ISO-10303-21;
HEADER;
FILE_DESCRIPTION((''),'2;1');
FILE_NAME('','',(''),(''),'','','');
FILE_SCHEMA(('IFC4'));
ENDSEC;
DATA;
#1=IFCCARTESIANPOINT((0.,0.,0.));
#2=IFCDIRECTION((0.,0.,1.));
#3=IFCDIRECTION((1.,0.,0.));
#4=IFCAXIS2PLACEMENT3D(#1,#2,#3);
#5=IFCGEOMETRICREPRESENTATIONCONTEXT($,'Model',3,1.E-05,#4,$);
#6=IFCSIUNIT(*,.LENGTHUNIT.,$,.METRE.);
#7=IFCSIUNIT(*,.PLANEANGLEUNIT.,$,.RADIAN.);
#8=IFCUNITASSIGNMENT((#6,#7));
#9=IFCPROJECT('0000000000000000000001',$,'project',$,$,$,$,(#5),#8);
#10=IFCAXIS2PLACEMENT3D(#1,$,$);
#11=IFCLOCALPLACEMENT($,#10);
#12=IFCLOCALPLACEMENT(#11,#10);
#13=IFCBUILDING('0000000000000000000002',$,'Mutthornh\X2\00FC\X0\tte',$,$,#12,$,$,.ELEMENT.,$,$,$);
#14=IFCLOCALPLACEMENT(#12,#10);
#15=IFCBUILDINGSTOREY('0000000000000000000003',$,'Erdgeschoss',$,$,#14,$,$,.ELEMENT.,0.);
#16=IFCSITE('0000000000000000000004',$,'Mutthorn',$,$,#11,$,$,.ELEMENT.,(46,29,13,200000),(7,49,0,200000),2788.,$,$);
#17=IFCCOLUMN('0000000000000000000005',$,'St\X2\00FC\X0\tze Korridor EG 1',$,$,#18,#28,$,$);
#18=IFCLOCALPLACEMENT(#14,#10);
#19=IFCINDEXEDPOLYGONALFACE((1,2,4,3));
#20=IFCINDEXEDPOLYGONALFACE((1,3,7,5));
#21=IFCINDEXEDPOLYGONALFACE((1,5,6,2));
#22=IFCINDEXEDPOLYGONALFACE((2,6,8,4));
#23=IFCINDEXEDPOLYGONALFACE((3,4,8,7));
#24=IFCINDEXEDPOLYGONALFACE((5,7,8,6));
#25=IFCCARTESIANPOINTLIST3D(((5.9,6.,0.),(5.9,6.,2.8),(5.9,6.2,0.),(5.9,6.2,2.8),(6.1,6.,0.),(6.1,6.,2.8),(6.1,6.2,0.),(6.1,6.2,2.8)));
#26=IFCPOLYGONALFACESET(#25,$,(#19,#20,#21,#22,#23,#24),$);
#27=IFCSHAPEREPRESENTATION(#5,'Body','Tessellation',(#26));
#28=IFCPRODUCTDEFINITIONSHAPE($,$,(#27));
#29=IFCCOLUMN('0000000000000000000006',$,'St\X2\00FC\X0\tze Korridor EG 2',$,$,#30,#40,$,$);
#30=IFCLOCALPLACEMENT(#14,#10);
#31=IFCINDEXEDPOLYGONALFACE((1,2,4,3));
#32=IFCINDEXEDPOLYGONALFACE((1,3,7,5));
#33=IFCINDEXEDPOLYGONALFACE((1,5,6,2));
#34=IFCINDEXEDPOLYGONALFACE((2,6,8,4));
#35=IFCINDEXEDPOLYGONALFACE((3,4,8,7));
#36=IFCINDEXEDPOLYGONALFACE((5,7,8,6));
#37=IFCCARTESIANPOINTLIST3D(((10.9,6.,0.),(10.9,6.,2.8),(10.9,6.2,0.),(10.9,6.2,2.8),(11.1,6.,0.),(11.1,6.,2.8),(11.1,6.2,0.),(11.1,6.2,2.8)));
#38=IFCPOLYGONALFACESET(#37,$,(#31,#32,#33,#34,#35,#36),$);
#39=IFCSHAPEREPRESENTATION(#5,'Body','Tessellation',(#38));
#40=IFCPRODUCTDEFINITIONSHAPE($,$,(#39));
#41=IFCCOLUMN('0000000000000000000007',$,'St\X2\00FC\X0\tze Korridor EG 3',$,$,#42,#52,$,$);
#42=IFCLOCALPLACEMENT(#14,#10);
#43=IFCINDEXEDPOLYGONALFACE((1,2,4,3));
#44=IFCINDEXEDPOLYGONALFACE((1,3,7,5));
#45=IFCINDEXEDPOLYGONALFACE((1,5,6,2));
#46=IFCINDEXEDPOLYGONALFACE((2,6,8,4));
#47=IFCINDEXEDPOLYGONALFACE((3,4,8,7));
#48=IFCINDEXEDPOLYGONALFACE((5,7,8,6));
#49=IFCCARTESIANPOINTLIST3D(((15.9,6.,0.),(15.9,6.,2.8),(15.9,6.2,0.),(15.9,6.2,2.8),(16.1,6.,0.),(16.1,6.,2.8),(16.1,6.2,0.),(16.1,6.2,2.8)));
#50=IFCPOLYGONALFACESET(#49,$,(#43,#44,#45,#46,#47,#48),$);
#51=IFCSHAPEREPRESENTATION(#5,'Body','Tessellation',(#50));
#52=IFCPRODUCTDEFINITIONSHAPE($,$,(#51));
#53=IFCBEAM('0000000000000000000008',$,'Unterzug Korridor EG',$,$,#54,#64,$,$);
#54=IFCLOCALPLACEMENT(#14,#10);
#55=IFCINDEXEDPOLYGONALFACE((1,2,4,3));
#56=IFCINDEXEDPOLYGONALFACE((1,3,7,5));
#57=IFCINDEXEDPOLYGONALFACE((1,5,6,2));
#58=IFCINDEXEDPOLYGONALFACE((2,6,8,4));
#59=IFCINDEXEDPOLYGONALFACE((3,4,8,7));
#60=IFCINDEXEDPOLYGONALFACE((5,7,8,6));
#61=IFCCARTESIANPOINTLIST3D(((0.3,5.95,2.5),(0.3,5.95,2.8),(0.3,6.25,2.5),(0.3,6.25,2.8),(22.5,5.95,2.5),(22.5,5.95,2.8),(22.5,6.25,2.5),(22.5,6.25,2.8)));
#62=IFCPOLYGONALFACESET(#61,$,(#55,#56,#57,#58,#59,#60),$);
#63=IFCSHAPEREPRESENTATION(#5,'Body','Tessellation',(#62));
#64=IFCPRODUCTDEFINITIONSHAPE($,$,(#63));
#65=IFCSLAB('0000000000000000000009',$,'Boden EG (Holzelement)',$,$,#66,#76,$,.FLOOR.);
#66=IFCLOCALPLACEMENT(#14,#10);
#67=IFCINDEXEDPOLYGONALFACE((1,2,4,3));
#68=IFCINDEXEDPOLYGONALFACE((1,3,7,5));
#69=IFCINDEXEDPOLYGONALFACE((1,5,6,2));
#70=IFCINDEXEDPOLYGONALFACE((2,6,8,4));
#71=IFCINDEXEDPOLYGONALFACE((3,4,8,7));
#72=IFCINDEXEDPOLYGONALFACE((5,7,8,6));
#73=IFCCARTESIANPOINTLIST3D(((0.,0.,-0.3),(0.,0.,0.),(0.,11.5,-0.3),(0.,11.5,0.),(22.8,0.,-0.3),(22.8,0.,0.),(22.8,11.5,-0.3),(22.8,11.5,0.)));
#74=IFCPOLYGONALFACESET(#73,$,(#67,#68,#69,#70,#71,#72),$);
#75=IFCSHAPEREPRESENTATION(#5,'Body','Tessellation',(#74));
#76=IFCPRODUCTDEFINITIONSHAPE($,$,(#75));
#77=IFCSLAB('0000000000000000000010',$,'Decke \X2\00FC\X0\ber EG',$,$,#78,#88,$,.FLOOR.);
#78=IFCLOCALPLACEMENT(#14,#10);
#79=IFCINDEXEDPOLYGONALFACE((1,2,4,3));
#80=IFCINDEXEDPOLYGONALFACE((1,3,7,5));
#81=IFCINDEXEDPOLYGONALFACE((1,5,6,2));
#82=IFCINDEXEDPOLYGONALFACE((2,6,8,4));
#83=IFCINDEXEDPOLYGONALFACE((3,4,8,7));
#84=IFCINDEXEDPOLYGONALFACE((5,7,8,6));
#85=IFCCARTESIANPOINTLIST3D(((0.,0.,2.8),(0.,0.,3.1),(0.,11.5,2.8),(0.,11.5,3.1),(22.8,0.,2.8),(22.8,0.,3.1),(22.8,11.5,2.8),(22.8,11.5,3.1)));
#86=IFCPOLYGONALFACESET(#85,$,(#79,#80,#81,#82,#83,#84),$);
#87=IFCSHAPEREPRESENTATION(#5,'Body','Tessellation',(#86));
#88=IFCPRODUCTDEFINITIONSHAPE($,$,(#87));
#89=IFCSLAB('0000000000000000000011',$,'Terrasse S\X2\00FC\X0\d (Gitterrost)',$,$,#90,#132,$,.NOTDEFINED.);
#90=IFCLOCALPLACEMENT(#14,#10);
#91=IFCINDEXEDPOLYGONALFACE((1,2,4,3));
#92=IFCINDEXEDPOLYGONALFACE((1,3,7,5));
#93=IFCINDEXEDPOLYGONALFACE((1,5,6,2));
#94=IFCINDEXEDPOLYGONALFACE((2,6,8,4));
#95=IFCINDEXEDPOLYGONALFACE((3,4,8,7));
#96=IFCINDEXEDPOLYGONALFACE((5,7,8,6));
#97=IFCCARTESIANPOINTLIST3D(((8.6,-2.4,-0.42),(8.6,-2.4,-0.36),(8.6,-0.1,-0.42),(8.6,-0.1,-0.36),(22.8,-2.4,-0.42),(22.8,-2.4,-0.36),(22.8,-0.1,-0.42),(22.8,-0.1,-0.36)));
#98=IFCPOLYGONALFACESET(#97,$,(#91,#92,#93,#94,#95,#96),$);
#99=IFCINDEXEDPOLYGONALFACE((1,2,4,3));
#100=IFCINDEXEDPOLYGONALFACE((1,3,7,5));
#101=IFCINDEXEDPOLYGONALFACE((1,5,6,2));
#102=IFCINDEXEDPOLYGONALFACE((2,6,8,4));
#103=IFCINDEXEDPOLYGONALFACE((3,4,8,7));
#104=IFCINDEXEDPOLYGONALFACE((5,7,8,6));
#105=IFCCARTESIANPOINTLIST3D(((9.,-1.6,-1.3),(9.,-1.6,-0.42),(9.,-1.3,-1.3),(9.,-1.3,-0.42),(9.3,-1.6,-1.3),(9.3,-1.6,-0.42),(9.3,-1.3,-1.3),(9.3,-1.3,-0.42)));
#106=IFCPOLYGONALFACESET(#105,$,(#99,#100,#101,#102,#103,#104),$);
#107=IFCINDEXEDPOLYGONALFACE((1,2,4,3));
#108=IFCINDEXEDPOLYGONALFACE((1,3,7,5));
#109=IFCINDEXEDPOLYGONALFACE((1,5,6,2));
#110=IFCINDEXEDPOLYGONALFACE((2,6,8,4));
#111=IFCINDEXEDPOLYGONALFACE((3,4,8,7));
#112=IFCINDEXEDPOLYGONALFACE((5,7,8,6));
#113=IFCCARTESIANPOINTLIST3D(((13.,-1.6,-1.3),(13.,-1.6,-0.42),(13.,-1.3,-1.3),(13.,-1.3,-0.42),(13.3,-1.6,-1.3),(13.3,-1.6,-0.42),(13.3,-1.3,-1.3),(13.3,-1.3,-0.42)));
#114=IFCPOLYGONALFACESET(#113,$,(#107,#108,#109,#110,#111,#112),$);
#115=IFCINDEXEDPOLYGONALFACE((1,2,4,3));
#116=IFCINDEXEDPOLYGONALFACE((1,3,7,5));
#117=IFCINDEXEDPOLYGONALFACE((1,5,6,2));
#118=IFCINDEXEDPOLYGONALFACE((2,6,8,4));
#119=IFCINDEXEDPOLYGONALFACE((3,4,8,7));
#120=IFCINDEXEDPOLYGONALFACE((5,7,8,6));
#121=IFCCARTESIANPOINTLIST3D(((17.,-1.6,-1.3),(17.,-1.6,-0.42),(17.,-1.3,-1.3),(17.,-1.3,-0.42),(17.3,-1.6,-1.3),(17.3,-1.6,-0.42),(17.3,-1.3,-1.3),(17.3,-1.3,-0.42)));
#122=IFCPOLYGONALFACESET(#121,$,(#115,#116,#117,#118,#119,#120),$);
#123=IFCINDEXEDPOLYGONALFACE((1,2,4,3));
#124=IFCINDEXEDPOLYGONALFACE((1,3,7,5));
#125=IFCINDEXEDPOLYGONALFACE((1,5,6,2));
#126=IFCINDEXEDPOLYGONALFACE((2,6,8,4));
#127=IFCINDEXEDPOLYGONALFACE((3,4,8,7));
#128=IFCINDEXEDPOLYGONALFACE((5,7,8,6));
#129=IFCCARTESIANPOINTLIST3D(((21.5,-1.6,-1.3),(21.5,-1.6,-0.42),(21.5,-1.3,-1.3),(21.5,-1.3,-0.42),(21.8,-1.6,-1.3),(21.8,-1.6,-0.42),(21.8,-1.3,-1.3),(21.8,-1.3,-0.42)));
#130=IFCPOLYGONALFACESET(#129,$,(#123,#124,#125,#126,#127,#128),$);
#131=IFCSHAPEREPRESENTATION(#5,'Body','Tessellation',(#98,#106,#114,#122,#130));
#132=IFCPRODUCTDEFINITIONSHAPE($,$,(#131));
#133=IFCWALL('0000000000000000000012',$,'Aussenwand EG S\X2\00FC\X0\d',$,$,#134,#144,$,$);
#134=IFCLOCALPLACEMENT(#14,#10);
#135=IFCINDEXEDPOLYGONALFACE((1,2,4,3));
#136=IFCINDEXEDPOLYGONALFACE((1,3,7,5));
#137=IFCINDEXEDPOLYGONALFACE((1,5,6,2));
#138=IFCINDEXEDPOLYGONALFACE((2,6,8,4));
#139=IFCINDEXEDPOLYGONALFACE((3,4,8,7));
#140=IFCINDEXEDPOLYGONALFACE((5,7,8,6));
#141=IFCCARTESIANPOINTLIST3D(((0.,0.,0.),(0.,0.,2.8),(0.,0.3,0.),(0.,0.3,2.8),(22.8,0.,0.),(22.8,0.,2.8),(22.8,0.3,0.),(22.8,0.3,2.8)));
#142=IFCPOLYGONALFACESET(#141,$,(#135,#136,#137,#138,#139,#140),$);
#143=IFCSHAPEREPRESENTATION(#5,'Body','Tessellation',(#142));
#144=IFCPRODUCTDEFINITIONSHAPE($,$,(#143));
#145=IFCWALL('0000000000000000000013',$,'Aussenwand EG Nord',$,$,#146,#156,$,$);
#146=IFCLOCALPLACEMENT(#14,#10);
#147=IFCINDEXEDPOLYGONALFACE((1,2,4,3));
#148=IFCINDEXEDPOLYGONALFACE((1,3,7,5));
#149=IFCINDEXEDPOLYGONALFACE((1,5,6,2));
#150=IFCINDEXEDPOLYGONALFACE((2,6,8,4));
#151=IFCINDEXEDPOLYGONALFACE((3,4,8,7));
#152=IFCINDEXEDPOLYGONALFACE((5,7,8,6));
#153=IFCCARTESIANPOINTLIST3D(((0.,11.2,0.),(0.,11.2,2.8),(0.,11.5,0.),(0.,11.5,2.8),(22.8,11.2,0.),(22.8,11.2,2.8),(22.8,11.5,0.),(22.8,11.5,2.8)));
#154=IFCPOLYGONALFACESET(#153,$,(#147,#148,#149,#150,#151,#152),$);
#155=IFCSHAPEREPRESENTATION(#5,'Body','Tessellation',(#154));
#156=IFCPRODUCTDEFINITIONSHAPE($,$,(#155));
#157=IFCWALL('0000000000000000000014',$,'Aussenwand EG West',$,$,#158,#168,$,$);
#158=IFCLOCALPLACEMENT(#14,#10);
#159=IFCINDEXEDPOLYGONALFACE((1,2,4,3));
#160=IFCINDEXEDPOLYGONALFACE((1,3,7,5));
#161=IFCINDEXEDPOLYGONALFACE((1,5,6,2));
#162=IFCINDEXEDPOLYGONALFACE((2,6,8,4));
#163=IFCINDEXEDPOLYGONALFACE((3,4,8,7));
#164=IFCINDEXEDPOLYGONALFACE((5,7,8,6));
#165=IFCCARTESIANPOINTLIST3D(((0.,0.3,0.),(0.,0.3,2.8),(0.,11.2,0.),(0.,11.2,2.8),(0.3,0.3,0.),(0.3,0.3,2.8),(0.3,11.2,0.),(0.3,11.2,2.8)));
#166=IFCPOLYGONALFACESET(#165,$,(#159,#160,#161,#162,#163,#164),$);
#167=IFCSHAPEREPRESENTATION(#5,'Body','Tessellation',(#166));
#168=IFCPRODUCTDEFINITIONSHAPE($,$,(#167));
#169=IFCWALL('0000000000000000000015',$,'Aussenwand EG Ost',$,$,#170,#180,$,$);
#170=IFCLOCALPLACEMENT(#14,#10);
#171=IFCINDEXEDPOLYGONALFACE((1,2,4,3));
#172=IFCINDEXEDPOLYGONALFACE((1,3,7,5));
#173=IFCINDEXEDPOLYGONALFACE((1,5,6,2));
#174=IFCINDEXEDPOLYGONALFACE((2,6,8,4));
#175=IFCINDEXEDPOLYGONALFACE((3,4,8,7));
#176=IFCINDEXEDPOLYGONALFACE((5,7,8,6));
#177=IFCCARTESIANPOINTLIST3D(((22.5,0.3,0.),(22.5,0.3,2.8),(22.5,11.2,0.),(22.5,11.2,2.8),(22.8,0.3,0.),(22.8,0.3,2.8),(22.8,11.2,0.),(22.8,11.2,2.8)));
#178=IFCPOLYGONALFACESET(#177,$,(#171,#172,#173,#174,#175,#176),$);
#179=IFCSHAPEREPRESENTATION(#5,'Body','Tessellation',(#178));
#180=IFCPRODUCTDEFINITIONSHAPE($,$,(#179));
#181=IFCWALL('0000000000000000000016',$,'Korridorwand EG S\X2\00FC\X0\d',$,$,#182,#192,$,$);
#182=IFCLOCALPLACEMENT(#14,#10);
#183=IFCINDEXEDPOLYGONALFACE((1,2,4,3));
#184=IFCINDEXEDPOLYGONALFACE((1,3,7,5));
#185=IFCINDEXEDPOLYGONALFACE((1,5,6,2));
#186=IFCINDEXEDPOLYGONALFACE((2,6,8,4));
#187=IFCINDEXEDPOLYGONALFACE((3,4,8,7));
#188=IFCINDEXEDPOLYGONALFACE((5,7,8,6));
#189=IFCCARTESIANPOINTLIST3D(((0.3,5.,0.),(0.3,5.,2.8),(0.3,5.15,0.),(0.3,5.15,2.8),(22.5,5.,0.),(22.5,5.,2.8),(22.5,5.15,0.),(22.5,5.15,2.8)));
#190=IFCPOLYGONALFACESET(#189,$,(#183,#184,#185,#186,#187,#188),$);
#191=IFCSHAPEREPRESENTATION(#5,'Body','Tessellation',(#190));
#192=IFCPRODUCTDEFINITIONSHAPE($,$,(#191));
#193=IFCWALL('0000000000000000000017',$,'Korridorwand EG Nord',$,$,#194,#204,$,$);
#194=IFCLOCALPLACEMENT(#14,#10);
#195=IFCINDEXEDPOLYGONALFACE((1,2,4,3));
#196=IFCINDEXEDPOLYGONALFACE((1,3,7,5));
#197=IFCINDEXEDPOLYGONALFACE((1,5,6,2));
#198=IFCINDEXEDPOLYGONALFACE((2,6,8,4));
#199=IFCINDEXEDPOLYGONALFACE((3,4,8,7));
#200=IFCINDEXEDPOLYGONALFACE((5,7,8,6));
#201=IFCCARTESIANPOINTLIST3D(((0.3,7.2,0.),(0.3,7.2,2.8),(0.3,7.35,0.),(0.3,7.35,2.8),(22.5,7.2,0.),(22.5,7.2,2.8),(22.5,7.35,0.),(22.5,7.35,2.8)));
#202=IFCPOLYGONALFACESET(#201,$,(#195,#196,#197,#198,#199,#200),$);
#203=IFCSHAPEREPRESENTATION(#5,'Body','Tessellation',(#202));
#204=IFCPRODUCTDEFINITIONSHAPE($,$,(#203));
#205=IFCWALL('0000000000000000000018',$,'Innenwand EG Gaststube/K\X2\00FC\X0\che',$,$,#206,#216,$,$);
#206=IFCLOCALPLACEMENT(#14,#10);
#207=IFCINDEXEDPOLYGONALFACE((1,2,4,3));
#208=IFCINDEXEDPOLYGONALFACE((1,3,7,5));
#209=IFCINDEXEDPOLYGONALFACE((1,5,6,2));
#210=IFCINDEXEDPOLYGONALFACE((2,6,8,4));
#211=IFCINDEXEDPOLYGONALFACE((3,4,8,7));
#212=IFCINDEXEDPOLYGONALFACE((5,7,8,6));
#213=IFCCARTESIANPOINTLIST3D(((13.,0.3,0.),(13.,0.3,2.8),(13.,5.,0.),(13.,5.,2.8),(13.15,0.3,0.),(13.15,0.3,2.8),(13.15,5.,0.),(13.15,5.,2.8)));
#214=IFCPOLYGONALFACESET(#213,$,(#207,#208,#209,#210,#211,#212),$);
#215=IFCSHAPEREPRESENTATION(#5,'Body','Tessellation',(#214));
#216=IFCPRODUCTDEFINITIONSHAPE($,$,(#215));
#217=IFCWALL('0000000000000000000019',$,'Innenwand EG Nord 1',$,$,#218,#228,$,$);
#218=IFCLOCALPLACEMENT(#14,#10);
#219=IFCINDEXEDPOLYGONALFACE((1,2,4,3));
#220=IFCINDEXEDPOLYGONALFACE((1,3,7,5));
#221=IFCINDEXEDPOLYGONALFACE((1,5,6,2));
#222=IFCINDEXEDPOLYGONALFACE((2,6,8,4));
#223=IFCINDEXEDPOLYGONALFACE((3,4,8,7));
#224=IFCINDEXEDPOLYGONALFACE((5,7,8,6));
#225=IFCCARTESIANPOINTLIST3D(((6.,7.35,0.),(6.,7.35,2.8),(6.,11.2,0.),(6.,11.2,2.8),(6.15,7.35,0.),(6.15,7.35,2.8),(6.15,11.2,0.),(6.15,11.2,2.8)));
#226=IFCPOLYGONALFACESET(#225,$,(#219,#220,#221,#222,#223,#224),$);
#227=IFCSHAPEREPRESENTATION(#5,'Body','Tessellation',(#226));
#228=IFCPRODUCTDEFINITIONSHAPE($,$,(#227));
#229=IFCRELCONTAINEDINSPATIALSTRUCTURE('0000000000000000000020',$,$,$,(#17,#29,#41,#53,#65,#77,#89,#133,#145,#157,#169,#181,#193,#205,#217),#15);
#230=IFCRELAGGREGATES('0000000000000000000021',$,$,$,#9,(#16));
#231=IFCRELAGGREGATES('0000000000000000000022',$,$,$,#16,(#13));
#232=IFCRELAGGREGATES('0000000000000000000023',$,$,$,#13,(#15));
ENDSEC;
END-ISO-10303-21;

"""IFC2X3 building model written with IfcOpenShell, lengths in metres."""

from ifc_helpers import new_model, si_unit, frame, frame_2d, origin, origin_with_axes, place, context, project, spatial, rectangle, extrude, element, save


model = new_model("IFC2X3")

# Units and contexts
model_context = context("Model", 3, precision=1e-05, world=origin_with_axes())
ifc_project = project(units=[si_unit("LENGTHUNIT", "METRE"), si_unit("PLANEANGLEUNIT", "RADIAN")], contexts=[model_context])

# Site, building, storey
site_placement = place(None, origin())
site = spatial("IfcSite", under=ifc_project, at=site_placement, Name="Mutthorn", CompositionType="ELEMENT", RefLatitude=(46, 29, 13, 200000), RefLongitude=(7, 49, 0, 200000), RefElevation=2788.0)
building_placement = place(site_placement, origin())
building = spatial("IfcBuilding", under=site, at=building_placement, Name="Mutthornhütte", CompositionType="ELEMENT")
storey_placement = place(building_placement, origin())
storey = spatial("IfcBuildingStorey", under=building, at=storey_placement, Name="Erdgeschoss", CompositionType="ELEMENT", Elevation=0.0)

# Columns
column_1_placement = place(storey_placement, origin())
element("IfcColumn", 1, at=column_1_placement, inside=storey, Name="Stütze Korridor EG 1", context=model_context, shape_type="SweptSolid", body=[
    extrude(rectangle(XDim=0.2, YDim=0.2, at=frame_2d((0.1, 0.1))), frame((5.9, 6.0, 0.0)), (0.0, 0.0, 1.0), 2.8),
])
column_2_placement = place(storey_placement, origin())
element("IfcColumn", 2, at=column_2_placement, inside=storey, Name="Stütze Korridor EG 2", context=model_context, shape_type="SweptSolid", body=[
    extrude(rectangle(XDim=0.2, YDim=0.2, at=frame_2d((0.1, 0.1))), frame((10.9, 6.0, 0.0)), (0.0, 0.0, 1.0), 2.8),
])
column_3_placement = place(storey_placement, origin())
element("IfcColumn", 3, at=column_3_placement, inside=storey, Name="Stütze Korridor EG 3", context=model_context, shape_type="SweptSolid", body=[
    extrude(rectangle(XDim=0.2, YDim=0.2, at=frame_2d((0.1, 0.1))), frame((15.9, 6.0, 0.0)), (0.0, 0.0, 1.0), 2.8),
])

# Beam
beam_placement = place(storey_placement, origin())
element("IfcBeam", 4, at=beam_placement, inside=storey, Name="Unterzug Korridor EG", context=model_context, shape_type="SweptSolid", body=[
    extrude(rectangle(XDim=22.2, YDim=0.3, at=frame_2d((11.1, 0.15))), frame((0.3, 5.95, 2.5)), (0.0, 0.0, 1.0), 0.3),
])

# Slabs
slab_1_placement = place(storey_placement, origin())
element("IfcSlab", 5, at=slab_1_placement, inside=storey, Name="Boden EG (Holzelement)", PredefinedType="FLOOR", context=model_context, shape_type="SweptSolid", body=[
    extrude(rectangle(XDim=22.8, YDim=11.5, at=frame_2d((11.4, 5.75))), frame((0.0, 0.0, -0.3)), (0.0, 0.0, 1.0), 0.3),
])
slab_2_placement = place(storey_placement, origin())
element("IfcSlab", 6, at=slab_2_placement, inside=storey, Name="Decke über EG", PredefinedType="FLOOR", context=model_context, shape_type="SweptSolid", body=[
    extrude(rectangle(XDim=22.8, YDim=11.5, at=frame_2d((11.4, 5.75))), frame((0.0, 0.0, 2.8)), (0.0, 0.0, 1.0), 0.3),
])
slab_3_placement = place(storey_placement, origin())
element("IfcSlab", 7, at=slab_3_placement, inside=storey, Name="Terrasse Süd (Gitterrost)", PredefinedType="NOTDEFINED", context=model_context, shape_type="SweptSolid", body=[
    extrude(rectangle(XDim=14.2, YDim=2.3, at=frame_2d((7.1, 1.15))), frame((8.6, -2.4, -0.42)), (0.0, 0.0, 1.0), 0.06),
    extrude(rectangle(XDim=0.3, YDim=0.3, at=frame_2d((0.15, 0.15))), frame((9.0, -1.6, -1.3)), (0.0, 0.0, 1.0), 0.88),
    extrude(rectangle(XDim=0.3, YDim=0.3, at=frame_2d((0.15, 0.15))), frame((13.0, -1.6, -1.3)), (0.0, 0.0, 1.0), 0.88),
    extrude(rectangle(XDim=0.3, YDim=0.3, at=frame_2d((0.15, 0.15))), frame((17.0, -1.6, -1.3)), (0.0, 0.0, 1.0), 0.88),
    extrude(rectangle(XDim=0.3, YDim=0.3, at=frame_2d((0.15, 0.15))), frame((21.5, -1.6, -1.3)), (0.0, 0.0, 1.0), 0.88),
])

# Walls
wall_1_placement = place(storey_placement, origin())
element("IfcWall", 8, at=wall_1_placement, inside=storey, Name="Aussenwand EG Süd", context=model_context, shape_type="SweptSolid", body=[
    extrude(rectangle(XDim=22.8, YDim=0.3, at=frame_2d((11.4, 0.15))), origin(), (0.0, 0.0, 1.0), 2.8),
])
wall_2_placement = place(storey_placement, origin())
element("IfcWall", 9, at=wall_2_placement, inside=storey, Name="Aussenwand EG Nord", context=model_context, shape_type="SweptSolid", body=[
    extrude(rectangle(XDim=22.8, YDim=0.3, at=frame_2d((11.4, 0.15))), frame((0.0, 11.2, 0.0)), (0.0, 0.0, 1.0), 2.8),
])
wall_3_placement = place(storey_placement, origin())
element("IfcWall", 10, at=wall_3_placement, inside=storey, Name="Aussenwand EG West", context=model_context, shape_type="SweptSolid", body=[
    extrude(rectangle(XDim=0.3, YDim=10.9, at=frame_2d((0.15, 5.45))), frame((0.0, 0.3, 0.0)), (0.0, 0.0, 1.0), 2.8),
])
wall_4_placement = place(storey_placement, origin())
element("IfcWall", 11, at=wall_4_placement, inside=storey, Name="Aussenwand EG Ost", context=model_context, shape_type="SweptSolid", body=[
    extrude(rectangle(XDim=0.3, YDim=10.9, at=frame_2d((0.15, 5.45))), frame((22.5, 0.3, 0.0)), (0.0, 0.0, 1.0), 2.8),
])
wall_5_placement = place(storey_placement, origin())
element("IfcWall", 12, at=wall_5_placement, inside=storey, Name="Korridorwand EG Süd", context=model_context, shape_type="SweptSolid", body=[
    extrude(rectangle(XDim=22.2, YDim=0.15, at=frame_2d((11.1, 0.075))), frame((0.3, 5.0, 0.0)), (0.0, 0.0, 1.0), 2.8),
])
wall_6_placement = place(storey_placement, origin())
element("IfcWall", 13, at=wall_6_placement, inside=storey, Name="Korridorwand EG Nord", context=model_context, shape_type="SweptSolid", body=[
    extrude(rectangle(XDim=22.2, YDim=0.15, at=frame_2d((11.1, 0.075))), frame((0.3, 7.2, 0.0)), (0.0, 0.0, 1.0), 2.8),
])
wall_7_placement = place(storey_placement, origin())
element("IfcWall", 14, at=wall_7_placement, inside=storey, Name="Innenwand EG Gaststube/Küche", context=model_context, shape_type="SweptSolid", body=[
    extrude(rectangle(XDim=0.15, YDim=4.7, at=frame_2d((0.075, 2.35))), frame((13.0, 0.3, 0.0)), (0.0, 0.0, 1.0), 2.8),
])
wall_8_placement = place(storey_placement, origin())
element("IfcWall", 15, at=wall_8_placement, inside=storey, Name="Innenwand EG Nord 1", context=model_context, shape_type="SweptSolid", body=[
    extrude(rectangle(XDim=0.15, YDim=3.85, at=frame_2d((0.075, 1.925))), frame((6.0, 7.35, 0.0)), (0.0, 0.0, 1.0), 2.8),
])

save(model, "model.ifc")
